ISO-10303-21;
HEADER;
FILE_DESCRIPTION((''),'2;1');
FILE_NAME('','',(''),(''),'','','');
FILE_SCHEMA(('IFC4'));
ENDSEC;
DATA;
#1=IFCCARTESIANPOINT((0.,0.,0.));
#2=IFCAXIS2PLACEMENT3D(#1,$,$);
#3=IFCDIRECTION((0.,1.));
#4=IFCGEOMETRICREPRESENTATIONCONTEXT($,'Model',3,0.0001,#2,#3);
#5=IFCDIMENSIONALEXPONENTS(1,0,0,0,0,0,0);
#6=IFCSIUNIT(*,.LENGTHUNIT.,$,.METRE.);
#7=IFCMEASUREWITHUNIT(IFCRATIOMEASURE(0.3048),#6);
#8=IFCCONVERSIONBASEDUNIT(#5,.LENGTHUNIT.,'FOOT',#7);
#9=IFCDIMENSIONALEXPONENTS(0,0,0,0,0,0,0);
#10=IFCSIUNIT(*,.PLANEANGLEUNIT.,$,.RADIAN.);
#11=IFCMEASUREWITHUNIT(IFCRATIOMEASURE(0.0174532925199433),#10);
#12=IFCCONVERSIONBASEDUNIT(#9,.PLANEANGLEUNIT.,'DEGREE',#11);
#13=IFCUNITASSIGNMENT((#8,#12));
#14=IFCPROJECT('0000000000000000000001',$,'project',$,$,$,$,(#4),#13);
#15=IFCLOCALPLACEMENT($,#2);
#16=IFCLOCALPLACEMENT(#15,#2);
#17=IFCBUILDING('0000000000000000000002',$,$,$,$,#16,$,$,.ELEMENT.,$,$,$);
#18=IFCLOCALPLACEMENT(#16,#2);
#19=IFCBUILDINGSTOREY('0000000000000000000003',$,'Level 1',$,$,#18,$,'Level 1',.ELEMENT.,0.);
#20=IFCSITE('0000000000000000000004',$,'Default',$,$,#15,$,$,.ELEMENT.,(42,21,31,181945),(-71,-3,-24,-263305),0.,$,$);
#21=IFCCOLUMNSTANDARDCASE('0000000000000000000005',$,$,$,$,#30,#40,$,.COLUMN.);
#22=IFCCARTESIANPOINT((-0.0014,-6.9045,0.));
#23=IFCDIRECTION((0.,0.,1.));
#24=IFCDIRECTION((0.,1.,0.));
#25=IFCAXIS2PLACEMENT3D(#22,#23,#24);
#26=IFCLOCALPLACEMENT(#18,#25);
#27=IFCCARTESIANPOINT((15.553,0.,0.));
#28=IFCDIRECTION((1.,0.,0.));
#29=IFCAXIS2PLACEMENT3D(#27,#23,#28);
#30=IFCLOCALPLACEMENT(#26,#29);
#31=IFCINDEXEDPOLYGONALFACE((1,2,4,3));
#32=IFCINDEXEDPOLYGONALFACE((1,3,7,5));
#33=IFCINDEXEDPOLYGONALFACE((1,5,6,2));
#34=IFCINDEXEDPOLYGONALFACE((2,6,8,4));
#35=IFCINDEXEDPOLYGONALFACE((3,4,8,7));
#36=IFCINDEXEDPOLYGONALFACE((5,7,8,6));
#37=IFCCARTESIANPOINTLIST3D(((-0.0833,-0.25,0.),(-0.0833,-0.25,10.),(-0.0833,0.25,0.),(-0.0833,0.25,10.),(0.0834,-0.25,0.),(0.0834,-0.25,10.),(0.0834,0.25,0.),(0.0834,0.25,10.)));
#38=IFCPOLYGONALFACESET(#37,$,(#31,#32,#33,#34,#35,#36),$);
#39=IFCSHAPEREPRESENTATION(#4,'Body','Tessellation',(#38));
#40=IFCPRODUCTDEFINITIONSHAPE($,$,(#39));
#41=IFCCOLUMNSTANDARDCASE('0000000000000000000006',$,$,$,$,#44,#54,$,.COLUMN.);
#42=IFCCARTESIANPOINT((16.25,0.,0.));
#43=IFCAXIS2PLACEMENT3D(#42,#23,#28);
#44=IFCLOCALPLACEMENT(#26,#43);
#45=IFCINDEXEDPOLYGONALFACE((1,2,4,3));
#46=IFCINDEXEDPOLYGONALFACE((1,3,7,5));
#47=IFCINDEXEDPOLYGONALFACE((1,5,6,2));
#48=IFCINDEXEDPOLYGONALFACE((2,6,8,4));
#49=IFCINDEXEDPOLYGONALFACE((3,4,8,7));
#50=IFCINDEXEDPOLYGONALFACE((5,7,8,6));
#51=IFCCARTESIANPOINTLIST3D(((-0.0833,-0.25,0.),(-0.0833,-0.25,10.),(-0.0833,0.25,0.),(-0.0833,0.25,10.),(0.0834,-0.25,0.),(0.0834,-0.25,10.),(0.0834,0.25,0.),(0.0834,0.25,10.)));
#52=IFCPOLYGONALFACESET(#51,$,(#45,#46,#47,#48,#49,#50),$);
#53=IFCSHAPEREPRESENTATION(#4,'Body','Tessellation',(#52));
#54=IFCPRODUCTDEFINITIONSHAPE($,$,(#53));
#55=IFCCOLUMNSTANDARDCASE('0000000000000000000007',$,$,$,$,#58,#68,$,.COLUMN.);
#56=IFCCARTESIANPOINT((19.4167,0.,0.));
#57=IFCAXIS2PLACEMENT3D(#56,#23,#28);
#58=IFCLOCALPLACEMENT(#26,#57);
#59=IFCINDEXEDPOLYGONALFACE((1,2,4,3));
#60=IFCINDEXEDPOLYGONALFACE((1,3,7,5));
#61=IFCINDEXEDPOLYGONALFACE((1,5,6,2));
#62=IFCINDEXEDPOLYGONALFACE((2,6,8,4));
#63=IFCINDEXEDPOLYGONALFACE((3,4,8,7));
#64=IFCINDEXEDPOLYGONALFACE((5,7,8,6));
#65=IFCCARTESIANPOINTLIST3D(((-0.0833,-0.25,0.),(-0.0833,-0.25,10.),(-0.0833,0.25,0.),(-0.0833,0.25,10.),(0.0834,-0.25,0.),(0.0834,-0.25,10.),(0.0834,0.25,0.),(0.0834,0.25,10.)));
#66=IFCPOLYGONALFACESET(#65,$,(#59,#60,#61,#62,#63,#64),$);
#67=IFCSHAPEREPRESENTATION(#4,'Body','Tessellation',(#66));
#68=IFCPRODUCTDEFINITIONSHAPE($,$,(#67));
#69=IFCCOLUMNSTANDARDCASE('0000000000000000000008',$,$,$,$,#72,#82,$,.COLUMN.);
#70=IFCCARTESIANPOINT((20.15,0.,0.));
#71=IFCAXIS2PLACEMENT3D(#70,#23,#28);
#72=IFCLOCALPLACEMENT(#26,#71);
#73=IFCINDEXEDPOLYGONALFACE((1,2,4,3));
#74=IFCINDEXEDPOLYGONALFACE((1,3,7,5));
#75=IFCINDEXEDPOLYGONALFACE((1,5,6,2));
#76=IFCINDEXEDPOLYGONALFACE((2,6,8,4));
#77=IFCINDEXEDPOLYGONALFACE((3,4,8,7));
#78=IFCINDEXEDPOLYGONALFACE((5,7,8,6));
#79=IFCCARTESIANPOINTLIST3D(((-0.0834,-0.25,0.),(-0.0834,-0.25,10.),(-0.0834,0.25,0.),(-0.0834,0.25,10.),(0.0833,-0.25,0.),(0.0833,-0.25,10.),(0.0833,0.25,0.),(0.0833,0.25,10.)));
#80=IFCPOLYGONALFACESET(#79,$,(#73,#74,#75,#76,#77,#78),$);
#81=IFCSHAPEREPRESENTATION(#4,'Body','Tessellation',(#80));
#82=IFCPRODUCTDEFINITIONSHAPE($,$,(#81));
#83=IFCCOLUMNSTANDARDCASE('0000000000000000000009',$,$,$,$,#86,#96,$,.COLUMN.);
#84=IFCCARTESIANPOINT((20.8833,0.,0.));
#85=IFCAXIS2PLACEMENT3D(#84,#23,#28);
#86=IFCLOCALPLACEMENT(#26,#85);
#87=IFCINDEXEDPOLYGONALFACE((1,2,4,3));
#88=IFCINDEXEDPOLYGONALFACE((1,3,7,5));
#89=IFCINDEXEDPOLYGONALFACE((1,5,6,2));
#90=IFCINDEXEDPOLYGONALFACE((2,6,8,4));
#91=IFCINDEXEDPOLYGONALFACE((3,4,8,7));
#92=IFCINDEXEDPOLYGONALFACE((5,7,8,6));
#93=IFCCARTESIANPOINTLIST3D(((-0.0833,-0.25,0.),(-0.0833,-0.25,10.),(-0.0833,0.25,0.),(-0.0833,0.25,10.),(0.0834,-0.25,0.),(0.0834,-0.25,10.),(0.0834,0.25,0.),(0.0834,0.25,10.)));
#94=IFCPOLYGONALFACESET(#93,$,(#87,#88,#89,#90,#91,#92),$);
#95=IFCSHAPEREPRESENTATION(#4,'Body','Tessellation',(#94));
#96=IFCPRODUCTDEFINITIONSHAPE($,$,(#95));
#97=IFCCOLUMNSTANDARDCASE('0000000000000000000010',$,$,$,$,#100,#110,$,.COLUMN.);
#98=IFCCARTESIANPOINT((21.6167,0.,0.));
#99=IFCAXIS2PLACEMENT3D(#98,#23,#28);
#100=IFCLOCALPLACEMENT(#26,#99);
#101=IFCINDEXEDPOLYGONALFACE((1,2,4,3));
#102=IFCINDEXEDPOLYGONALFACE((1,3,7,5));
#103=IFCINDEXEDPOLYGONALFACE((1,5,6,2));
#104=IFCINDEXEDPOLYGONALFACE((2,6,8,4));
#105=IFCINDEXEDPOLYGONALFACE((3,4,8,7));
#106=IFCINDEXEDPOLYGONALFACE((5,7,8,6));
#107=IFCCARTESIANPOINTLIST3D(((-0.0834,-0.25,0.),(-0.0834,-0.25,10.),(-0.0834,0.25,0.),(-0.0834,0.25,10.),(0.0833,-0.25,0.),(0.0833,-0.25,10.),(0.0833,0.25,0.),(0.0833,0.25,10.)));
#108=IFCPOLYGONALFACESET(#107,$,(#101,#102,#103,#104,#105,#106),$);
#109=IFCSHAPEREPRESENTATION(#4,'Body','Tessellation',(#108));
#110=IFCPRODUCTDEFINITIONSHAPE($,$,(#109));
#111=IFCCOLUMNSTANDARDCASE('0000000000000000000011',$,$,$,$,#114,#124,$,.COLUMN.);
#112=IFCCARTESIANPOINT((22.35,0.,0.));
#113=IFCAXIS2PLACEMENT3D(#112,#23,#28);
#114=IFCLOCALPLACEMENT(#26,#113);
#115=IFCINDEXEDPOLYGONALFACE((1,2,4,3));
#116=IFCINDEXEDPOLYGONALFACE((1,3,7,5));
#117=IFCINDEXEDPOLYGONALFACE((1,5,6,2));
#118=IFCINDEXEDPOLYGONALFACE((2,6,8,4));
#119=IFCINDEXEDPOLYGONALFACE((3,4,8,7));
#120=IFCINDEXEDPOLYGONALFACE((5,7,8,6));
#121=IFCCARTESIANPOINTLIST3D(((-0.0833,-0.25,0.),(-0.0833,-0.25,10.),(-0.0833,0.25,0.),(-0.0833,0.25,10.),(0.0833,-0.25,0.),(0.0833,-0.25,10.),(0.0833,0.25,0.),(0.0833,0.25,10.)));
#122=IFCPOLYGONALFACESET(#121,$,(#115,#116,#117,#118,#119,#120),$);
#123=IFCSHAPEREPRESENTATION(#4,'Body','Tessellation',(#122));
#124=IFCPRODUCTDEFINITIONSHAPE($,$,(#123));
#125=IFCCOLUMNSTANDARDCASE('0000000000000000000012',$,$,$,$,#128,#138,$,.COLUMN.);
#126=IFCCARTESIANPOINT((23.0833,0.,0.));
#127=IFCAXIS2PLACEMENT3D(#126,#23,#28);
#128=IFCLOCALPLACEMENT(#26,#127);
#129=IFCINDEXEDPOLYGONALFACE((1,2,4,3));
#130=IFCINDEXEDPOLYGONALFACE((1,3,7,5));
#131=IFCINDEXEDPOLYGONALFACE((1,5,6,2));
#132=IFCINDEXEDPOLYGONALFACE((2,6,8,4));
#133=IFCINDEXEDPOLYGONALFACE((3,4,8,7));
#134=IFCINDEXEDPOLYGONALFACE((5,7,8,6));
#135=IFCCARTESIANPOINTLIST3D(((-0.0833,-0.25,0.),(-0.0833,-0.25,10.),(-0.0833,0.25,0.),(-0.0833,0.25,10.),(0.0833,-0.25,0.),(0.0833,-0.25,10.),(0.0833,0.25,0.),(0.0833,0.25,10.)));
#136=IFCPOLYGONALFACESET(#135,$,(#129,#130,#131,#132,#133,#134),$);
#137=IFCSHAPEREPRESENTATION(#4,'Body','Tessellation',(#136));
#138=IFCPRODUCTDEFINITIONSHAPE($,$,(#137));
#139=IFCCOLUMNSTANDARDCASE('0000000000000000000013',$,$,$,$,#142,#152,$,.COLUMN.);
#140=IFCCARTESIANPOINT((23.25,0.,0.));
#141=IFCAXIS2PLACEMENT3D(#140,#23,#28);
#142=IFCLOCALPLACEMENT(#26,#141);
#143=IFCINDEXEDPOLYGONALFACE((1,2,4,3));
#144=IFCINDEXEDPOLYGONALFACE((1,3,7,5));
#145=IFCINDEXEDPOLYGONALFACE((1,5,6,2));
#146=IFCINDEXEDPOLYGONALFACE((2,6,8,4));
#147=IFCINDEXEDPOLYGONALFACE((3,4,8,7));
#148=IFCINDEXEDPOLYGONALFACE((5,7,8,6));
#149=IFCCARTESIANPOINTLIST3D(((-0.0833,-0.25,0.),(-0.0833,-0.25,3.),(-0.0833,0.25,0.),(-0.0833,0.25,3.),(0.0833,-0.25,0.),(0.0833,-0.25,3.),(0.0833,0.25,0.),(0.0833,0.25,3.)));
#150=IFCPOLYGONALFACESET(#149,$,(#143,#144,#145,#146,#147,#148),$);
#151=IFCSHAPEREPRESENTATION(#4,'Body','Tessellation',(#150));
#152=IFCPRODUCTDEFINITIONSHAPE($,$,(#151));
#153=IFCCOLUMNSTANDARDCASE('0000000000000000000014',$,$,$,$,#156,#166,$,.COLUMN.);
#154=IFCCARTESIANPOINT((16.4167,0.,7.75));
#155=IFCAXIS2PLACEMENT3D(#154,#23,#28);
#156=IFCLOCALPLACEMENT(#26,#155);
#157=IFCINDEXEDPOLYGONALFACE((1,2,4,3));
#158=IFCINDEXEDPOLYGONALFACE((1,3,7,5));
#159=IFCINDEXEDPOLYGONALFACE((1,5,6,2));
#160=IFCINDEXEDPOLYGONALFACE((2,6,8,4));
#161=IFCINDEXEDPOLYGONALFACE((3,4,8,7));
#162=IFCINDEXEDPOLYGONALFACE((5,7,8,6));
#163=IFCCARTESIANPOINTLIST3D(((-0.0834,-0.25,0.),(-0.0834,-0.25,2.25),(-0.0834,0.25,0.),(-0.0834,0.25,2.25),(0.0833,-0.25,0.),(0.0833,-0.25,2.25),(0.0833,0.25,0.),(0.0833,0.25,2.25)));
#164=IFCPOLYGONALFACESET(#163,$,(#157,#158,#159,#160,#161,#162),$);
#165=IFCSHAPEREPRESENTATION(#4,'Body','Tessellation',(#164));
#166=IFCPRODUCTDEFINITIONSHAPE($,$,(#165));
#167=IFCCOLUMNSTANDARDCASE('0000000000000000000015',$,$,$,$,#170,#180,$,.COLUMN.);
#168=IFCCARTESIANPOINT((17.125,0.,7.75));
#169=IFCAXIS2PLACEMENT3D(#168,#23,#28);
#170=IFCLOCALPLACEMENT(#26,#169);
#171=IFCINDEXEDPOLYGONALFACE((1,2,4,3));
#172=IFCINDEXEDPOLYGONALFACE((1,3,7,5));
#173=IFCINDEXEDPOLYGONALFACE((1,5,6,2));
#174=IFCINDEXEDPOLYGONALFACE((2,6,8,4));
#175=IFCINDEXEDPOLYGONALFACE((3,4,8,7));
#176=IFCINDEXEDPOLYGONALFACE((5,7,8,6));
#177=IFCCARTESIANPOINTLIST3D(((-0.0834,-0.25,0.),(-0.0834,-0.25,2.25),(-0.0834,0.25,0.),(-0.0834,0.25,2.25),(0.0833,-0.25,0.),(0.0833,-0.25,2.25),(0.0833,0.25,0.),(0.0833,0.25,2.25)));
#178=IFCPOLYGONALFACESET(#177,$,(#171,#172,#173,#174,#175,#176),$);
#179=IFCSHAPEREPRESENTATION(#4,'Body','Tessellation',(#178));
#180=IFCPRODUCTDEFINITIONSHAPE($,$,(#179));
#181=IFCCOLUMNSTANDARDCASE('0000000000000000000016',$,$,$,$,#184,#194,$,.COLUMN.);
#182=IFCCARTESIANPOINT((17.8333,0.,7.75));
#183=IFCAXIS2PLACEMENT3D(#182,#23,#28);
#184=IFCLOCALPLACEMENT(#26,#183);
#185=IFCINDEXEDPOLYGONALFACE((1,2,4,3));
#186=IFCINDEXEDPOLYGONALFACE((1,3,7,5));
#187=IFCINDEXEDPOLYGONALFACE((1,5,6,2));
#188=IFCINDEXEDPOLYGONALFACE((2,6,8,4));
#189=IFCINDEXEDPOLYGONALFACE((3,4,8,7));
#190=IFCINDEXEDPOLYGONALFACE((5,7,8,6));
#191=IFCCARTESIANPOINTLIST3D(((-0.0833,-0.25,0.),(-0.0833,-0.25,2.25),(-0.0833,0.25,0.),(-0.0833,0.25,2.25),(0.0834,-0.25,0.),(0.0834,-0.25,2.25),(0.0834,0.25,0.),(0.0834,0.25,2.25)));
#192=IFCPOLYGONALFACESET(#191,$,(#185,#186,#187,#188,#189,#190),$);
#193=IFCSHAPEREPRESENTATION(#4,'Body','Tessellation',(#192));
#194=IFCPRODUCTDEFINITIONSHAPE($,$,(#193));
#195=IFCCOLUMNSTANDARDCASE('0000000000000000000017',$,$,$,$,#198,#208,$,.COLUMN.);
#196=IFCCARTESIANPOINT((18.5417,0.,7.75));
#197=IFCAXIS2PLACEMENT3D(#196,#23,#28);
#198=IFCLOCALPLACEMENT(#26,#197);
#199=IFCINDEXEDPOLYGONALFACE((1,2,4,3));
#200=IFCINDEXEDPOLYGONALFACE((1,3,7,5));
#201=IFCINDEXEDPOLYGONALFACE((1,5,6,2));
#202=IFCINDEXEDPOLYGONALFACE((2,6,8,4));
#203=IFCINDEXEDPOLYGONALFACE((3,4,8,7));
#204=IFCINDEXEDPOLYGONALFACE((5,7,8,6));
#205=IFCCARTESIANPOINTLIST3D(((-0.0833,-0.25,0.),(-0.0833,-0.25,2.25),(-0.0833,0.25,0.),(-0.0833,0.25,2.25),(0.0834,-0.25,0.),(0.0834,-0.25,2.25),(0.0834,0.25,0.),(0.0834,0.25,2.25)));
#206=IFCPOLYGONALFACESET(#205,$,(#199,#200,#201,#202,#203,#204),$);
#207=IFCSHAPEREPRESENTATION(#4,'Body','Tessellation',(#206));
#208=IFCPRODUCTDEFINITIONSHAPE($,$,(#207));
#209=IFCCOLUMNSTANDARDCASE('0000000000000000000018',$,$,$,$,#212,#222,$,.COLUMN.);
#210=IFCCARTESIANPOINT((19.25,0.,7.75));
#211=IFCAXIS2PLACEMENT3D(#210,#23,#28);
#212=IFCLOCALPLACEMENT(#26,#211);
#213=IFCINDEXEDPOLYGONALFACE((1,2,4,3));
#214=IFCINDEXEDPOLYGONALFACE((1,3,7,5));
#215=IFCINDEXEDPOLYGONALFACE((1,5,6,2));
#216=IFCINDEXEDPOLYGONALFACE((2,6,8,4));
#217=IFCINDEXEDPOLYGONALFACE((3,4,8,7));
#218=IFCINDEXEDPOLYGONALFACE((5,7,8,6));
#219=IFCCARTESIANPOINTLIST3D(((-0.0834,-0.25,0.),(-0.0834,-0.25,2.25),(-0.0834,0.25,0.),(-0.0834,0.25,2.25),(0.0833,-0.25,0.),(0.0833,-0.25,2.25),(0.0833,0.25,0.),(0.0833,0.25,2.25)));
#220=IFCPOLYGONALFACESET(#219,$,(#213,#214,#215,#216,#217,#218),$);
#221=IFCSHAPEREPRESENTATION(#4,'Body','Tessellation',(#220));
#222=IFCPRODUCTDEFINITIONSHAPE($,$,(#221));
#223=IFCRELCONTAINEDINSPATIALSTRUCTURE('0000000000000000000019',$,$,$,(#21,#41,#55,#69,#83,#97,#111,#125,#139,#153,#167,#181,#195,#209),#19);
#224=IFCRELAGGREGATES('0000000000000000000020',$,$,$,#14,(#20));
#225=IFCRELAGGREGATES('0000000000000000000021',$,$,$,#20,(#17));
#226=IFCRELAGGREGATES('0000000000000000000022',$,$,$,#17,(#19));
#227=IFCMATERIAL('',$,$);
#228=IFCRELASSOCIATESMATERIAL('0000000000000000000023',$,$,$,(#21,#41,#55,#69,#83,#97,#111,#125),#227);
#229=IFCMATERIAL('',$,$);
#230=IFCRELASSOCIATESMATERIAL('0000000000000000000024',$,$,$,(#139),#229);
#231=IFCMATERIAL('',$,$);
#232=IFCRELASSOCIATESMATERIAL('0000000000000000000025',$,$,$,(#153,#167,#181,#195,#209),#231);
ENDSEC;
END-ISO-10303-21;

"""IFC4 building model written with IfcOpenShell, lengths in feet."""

from ifc_helpers import new_model, entity, si_unit, converted_unit, direction, frame, origin, place, context, project, spatial, rectangle, extrude, material, element, save


model = new_model("IFC4")

# Units and contexts
model_context = context("Model", 3, precision=0.0001, world=origin(), true_north=direction((0.0, 1.0)))
ifc_project = project(units=[converted_unit("LENGTHUNIT", "FOOT", entity("IfcRatioMeasure", 0.3048), si_unit("LENGTHUNIT", "METRE"), dimensions=[1, 0, 0, 0, 0, 0, 0]), converted_unit("PLANEANGLEUNIT", "DEGREE", entity("IfcRatioMeasure", 0.0174532925199433), si_unit("PLANEANGLEUNIT", "RADIAN"), dimensions=[0, 0, 0, 0, 0, 0, 0])], contexts=[model_context])

# Site, building, storey
site_placement = place(None, origin())
site = spatial("IfcSite", under=ifc_project, at=site_placement, Name="Default", CompositionType="ELEMENT", RefLatitude=(42, 21, 31, 181945), RefLongitude=(-71, -3, -24, -263305), RefElevation=0.0)
building_placement = place(site_placement, origin())
building = spatial("IfcBuilding", under=site, at=building_placement, CompositionType="ELEMENT")
storey_placement = place(building_placement, origin())
storey = spatial("IfcBuildingStorey", under=building, at=storey_placement, Name="Level 1", LongName="Level 1", CompositionType="ELEMENT", Elevation=0.0)

# Columns
ifc_material_1 = material(Name="")
placement = place(storey_placement, frame((-0.0014, -6.9045, 0.0), z_axis=(0.0, 0.0, 1.0), x_axis=(0.0, 1.0, 0.0)))
for number, where, z_axis, x_axis in (
    (1, (15.553, 0.0, 0.0), (0.0, 0.0, 1.0), (1.0, 0.0, 0.0)),
    (2, (16.25, 0.0, 0.0), (0.0, 0.0, 1.0), (1.0, 0.0, 0.0)),
    (3, (19.4167, 0.0, 0.0), (0.0, 0.0, 1.0), (1.0, 0.0, 0.0)),
    (4, (20.15, 0.0, 0.0), (0.0, 0.0, 1.0), (1.0, 0.0, 0.0)),
    (5, (20.8833, 0.0, 0.0), (0.0, 0.0, 1.0), (1.0, 0.0, 0.0)),
    (6, (21.6167, 0.0, 0.0), (0.0, 0.0, 1.0), (1.0, 0.0, 0.0)),
    (7, (22.35, 0.0, 0.0), (0.0, 0.0, 1.0), (1.0, 0.0, 0.0)),
    (8, (23.0833, 0.0, 0.0), (0.0, 0.0, 1.0), (1.0, 0.0, 0.0)),
):
    element("IfcColumnStandardCase", number, at=place(placement, frame(where, z_axis=z_axis, x_axis=x_axis)), inside=storey, material=ifc_material_1, PredefinedType="COLUMN", context=model_context, shape_type="SweptSolid", body=[
        extrude(rectangle(XDim=0.1667, YDim=0.5), origin(), (0.0, 0.0, 1.0), 10.0),
    ])
ifc_material_2 = material(Name="")
for number, where, z_axis, x_axis in (
    (9, (23.25, 0.0, 0.0), (0.0, 0.0, 1.0), (1.0, 0.0, 0.0)),
):
    element("IfcColumnStandardCase", number, at=place(placement, frame(where, z_axis=z_axis, x_axis=x_axis)), inside=storey, material=ifc_material_2, PredefinedType="COLUMN", context=model_context, shape_type="SweptSolid", body=[
        extrude(rectangle(XDim=0.1667, YDim=0.5), origin(), (0.0, 0.0, 1.0), 3.0),
    ])
ifc_material_3 = material(Name="")
for number, where, z_axis, x_axis in (
    (10, (16.4167, 0.0, 7.75), (0.0, 0.0, 1.0), (1.0, 0.0, 0.0)),
    (11, (17.125, 0.0, 7.75), (0.0, 0.0, 1.0), (1.0, 0.0, 0.0)),
    (12, (17.8333, 0.0, 7.75), (0.0, 0.0, 1.0), (1.0, 0.0, 0.0)),
    (13, (18.5417, 0.0, 7.75), (0.0, 0.0, 1.0), (1.0, 0.0, 0.0)),
    (14, (19.25, 0.0, 7.75), (0.0, 0.0, 1.0), (1.0, 0.0, 0.0)),
):
    element("IfcColumnStandardCase", number, at=place(placement, frame(where, z_axis=z_axis, x_axis=x_axis)), inside=storey, material=ifc_material_3, PredefinedType="COLUMN", context=model_context, shape_type="SweptSolid", body=[
        extrude(rectangle(XDim=0.1667, YDim=0.5), origin(), (0.0, 0.0, 1.0), 2.25),
    ])

save(model, "model.ifc")
